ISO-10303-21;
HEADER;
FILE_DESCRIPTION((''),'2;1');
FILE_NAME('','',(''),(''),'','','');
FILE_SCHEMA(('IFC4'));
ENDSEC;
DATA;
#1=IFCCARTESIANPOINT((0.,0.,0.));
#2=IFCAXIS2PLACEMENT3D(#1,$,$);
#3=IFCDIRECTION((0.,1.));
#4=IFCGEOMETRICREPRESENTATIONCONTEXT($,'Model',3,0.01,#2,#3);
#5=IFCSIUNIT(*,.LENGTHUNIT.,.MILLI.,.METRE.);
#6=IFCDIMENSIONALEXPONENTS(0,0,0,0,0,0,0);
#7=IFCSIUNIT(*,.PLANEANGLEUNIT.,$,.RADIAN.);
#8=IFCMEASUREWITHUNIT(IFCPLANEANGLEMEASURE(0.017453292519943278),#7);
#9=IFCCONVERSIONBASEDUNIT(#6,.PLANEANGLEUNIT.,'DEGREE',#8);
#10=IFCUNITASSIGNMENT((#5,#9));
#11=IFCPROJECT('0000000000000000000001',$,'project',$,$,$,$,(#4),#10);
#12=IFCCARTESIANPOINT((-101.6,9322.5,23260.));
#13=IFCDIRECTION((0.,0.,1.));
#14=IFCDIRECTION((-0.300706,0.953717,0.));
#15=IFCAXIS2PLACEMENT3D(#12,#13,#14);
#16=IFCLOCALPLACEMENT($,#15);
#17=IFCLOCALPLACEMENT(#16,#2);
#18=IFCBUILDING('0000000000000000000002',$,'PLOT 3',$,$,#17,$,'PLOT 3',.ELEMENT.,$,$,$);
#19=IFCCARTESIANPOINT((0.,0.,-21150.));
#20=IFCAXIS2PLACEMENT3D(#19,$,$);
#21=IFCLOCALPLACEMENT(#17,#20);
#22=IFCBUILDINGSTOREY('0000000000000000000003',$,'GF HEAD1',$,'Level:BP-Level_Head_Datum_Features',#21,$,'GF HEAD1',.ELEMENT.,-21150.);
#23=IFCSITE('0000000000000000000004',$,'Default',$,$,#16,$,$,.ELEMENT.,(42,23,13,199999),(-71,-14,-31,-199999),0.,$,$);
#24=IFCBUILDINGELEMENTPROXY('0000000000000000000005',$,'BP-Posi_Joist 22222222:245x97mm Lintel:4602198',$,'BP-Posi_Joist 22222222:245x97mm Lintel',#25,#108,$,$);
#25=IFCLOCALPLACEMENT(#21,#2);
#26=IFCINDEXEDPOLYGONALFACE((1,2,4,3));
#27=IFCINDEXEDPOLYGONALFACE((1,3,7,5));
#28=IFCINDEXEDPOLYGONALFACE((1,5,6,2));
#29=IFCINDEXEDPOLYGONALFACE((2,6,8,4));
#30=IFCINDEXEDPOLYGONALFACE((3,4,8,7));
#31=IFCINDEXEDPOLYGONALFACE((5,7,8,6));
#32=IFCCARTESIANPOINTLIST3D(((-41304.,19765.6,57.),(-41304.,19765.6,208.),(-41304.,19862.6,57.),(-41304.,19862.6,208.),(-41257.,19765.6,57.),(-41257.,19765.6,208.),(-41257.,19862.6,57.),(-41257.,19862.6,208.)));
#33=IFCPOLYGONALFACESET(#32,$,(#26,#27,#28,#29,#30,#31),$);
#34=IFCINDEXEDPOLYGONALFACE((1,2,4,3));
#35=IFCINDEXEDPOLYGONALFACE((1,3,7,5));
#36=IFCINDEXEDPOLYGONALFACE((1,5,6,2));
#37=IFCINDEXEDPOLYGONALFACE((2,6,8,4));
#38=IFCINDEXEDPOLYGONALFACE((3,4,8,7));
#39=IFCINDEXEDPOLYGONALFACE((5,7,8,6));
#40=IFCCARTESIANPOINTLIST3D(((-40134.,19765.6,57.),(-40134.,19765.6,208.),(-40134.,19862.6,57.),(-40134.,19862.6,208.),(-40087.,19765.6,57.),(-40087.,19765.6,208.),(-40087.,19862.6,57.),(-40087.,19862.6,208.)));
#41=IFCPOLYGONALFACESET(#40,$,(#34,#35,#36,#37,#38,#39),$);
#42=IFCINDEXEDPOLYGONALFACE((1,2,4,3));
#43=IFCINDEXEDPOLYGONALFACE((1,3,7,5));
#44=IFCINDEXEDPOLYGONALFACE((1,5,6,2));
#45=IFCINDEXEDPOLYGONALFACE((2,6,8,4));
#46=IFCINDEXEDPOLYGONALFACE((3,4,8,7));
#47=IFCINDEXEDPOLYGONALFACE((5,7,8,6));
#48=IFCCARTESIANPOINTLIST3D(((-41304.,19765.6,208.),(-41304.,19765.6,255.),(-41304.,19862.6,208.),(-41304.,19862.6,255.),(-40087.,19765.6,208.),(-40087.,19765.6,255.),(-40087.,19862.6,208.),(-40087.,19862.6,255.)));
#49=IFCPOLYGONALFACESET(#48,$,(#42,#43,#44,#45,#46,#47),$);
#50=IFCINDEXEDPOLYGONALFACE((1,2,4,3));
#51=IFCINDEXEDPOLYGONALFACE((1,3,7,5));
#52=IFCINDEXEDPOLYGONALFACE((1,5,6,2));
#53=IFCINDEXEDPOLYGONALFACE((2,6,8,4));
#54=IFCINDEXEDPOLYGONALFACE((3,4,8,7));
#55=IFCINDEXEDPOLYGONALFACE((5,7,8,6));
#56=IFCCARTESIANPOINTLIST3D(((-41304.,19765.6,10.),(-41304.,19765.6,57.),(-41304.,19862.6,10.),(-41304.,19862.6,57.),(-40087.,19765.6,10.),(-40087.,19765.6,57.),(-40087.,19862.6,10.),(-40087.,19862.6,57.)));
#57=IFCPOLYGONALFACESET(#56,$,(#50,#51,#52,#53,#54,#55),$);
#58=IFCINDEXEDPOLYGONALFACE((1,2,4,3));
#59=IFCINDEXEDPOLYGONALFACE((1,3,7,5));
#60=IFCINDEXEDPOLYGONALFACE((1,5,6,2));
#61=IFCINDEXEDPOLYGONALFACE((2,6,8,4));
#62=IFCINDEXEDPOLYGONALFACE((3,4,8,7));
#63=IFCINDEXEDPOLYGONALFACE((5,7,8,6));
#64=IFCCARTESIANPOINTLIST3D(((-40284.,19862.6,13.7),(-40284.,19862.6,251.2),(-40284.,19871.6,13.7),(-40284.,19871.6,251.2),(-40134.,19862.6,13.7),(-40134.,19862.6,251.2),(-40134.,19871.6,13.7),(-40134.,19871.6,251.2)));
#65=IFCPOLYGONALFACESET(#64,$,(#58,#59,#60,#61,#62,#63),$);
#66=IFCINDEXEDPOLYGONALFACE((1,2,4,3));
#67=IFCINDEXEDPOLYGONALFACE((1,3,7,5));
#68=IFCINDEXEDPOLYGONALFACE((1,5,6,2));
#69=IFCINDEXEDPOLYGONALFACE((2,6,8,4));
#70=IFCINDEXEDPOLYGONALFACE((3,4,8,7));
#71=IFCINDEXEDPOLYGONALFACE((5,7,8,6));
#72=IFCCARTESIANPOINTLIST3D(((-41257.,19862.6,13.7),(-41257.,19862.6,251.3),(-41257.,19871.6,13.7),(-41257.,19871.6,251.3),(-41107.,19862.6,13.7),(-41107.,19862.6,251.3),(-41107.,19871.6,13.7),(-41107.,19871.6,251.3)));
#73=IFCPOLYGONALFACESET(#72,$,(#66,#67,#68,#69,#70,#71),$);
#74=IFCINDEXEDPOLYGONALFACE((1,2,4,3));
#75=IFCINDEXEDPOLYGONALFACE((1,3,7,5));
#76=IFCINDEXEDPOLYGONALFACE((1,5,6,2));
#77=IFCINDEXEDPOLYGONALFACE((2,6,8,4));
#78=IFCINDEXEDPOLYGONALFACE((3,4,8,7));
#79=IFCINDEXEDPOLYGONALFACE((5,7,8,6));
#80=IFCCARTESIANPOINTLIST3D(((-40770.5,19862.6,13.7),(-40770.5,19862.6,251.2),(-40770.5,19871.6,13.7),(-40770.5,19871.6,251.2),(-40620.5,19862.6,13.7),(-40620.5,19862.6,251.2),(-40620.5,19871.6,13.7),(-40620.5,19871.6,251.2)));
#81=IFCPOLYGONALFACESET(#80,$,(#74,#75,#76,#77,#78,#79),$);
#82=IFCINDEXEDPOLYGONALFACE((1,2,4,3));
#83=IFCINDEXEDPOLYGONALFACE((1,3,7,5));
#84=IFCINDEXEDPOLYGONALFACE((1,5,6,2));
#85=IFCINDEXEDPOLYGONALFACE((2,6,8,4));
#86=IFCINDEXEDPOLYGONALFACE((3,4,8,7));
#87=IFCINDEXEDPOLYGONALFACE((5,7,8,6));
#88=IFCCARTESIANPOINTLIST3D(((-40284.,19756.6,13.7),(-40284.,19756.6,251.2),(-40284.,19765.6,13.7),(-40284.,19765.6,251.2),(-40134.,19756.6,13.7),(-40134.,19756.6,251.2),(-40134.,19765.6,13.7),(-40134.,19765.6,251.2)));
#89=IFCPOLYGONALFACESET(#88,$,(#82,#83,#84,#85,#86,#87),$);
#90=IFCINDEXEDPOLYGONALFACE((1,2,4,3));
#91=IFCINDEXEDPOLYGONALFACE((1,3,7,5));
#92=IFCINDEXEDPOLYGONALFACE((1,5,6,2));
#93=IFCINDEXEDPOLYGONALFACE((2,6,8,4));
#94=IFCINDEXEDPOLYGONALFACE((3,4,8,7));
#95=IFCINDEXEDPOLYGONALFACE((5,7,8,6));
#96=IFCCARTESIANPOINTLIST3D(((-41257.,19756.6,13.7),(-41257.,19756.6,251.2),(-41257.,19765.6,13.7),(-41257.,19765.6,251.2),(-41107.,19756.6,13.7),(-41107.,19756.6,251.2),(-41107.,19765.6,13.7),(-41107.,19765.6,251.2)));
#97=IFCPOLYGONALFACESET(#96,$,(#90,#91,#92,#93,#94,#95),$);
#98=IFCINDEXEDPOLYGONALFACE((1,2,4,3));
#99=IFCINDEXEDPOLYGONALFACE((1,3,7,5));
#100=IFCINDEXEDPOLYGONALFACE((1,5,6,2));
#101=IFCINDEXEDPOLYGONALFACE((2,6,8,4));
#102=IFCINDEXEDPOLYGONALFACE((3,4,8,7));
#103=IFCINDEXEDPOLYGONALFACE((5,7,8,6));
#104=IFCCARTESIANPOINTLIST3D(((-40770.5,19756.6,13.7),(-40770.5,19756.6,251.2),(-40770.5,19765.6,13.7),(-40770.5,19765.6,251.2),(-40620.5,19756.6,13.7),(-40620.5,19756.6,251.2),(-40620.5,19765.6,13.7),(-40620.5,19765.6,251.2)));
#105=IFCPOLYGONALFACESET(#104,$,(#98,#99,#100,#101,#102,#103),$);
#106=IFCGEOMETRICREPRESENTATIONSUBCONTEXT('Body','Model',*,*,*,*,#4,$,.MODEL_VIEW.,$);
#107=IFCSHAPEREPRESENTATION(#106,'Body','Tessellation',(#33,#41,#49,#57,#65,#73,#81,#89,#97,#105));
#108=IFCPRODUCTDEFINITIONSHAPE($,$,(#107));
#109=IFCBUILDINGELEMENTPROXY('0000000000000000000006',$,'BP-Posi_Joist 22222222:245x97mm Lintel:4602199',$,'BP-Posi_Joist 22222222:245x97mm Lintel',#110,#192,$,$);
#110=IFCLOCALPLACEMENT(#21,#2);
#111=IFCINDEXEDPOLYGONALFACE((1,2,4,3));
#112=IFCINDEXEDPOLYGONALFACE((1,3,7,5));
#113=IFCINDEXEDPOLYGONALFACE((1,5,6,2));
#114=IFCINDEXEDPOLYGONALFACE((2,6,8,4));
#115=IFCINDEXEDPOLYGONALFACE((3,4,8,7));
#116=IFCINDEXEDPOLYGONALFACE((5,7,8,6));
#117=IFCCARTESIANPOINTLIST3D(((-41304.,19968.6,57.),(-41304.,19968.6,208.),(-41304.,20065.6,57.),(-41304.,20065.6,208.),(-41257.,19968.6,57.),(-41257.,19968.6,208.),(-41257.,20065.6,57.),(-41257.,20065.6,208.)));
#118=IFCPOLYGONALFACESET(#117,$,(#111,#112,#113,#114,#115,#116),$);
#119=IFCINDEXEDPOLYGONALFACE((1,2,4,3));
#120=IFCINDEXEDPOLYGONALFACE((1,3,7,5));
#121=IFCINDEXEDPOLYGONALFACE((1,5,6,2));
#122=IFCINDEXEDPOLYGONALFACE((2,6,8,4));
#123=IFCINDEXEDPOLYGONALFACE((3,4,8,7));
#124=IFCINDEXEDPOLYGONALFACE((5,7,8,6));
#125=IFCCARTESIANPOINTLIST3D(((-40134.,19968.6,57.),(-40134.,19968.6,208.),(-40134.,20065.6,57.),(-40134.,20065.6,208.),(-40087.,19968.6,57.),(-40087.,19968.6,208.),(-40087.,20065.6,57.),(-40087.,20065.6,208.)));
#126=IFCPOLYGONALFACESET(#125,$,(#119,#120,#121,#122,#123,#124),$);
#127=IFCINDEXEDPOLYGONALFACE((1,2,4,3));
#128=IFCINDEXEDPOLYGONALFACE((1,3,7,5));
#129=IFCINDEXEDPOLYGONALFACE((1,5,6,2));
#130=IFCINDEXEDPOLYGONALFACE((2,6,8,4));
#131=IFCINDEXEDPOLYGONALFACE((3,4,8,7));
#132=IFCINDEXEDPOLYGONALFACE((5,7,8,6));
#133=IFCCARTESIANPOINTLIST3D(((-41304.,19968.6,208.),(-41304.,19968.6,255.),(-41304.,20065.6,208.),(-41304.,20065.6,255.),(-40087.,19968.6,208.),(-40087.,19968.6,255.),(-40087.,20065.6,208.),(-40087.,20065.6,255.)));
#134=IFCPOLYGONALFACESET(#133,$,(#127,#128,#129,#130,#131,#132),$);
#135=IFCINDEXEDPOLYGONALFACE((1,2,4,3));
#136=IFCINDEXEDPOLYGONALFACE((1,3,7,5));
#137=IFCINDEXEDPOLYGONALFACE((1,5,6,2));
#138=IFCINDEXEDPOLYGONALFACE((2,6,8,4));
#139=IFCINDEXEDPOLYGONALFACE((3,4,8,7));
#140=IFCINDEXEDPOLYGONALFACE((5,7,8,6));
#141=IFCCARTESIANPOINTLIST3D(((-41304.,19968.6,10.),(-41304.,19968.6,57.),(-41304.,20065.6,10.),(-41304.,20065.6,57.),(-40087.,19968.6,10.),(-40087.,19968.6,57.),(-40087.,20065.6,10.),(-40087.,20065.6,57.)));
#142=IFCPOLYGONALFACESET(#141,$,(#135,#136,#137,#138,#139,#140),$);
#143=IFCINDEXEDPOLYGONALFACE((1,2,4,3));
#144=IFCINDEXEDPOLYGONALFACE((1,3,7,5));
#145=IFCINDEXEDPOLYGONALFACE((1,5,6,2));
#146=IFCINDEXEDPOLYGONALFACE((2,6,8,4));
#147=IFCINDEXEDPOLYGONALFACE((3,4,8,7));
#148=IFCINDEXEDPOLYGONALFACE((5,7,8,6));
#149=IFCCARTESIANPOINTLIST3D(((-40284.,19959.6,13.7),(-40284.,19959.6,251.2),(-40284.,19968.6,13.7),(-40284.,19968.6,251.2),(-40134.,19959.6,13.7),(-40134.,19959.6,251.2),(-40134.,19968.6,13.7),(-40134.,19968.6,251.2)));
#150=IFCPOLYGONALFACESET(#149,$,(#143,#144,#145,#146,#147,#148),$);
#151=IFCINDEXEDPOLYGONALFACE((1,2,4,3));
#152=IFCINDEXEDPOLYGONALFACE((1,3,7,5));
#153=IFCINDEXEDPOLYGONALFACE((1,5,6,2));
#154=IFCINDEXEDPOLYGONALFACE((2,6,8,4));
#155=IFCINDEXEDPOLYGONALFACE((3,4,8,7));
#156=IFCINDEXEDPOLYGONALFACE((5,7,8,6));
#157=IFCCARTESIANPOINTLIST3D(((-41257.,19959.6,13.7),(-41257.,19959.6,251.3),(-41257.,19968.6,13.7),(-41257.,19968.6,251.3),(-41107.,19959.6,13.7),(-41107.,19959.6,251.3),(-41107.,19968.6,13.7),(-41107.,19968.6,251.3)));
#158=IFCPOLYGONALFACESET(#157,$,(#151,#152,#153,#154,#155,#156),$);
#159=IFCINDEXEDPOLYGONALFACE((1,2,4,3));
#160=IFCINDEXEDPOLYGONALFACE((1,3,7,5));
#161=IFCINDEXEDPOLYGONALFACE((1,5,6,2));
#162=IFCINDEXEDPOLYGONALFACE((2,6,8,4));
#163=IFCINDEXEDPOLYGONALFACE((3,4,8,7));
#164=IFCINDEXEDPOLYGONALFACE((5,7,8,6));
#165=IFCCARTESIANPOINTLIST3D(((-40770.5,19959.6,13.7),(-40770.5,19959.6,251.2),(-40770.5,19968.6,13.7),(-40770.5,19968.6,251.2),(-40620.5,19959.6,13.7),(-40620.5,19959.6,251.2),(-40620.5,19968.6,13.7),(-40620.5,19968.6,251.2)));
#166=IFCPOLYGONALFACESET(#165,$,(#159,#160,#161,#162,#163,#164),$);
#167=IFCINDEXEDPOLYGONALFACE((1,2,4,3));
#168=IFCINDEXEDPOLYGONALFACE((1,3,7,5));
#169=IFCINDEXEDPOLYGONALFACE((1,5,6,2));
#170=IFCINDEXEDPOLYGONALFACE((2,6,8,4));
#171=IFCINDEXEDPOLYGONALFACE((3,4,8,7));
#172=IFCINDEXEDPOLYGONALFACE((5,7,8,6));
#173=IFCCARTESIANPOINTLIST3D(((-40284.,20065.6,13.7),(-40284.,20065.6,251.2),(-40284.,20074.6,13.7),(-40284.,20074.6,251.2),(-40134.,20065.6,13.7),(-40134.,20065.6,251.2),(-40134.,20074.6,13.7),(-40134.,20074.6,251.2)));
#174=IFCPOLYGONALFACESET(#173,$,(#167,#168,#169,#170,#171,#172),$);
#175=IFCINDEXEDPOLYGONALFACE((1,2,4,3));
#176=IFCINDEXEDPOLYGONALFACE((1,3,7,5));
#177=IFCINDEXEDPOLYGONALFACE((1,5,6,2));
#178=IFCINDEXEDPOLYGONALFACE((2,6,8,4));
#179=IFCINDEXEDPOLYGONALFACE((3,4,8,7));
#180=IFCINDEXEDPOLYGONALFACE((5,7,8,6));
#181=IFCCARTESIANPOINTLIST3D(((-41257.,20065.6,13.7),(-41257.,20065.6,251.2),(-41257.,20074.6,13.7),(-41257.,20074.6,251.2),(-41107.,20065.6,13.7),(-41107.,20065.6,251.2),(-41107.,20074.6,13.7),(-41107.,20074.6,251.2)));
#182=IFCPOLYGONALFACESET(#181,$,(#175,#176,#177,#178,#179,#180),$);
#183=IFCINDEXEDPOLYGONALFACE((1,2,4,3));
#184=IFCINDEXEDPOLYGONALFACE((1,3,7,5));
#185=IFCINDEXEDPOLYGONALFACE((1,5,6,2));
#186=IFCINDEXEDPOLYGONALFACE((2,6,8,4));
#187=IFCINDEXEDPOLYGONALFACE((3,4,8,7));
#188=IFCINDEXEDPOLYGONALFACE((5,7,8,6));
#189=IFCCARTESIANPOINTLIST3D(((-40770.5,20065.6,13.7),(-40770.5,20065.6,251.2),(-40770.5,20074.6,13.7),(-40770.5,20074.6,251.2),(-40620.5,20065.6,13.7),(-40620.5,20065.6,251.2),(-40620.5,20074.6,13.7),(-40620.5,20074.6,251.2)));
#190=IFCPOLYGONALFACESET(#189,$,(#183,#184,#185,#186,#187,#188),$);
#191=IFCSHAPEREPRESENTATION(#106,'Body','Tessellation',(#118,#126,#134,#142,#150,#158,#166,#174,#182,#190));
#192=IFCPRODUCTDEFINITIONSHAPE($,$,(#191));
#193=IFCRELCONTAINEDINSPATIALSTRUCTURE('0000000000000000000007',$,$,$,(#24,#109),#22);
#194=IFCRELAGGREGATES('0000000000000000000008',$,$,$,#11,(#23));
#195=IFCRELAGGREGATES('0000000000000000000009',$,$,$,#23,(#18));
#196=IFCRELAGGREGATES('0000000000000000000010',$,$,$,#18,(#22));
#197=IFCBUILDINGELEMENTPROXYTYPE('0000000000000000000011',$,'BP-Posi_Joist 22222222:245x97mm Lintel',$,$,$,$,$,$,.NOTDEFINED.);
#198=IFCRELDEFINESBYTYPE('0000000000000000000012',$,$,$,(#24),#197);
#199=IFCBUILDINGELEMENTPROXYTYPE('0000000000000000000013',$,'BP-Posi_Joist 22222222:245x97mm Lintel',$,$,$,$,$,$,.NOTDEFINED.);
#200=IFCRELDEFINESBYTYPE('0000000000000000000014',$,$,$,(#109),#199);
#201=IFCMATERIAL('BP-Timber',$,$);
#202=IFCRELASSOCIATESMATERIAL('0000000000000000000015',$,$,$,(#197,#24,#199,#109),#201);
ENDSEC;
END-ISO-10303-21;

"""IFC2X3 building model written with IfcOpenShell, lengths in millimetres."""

from ifc_helpers import new_model, entity, si_unit, converted_unit, direction, frame, frame_2d, origin, origin_2d_with_axis, place, context, subcontext, project, spatial, rectangle, extrude, source, transform, mapped, material, type_object, type_shapes, element, save


model = new_model("IFC2X3")

# Units and contexts
model_context = context("Model", 3, precision=0.01, world=origin(), true_north=direction((0.0, 1.0)))
body_context = subcontext(model_context, "Body", "Model", "MODEL_VIEW")
ifc_project = project(units=[si_unit("LENGTHUNIT", "METRE", prefix="MILLI"), converted_unit("PLANEANGLEUNIT", "DEGREE", entity("IfcPlaneAngleMeasure", 0.017453292519943278), si_unit("PLANEANGLEUNIT", "RADIAN"), dimensions=[0, 0, 0, 0, 0, 0, 0])], contexts=[model_context])

# Site, building, storey
site_placement = place(None, frame((-101.6, 9322.5, 23260.0), z_axis=(0.0, 0.0, 1.0), x_axis=(-0.300706, 0.953717, 0.0)))
site = spatial("IfcSite", under=ifc_project, at=site_placement, Name="Default", CompositionType="ELEMENT", RefLatitude=(42, 23, 13, 199999), RefLongitude=(-71, -14, -31, -199999), RefElevation=0.0)
building_placement = place(site_placement, origin())
building = spatial("IfcBuilding", under=site, at=building_placement, Name="PLOT 3", LongName="PLOT 3", CompositionType="ELEMENT")
storey_placement = place(building_placement, frame((0.0, 0.0, -21150.0)))
storey = spatial("IfcBuildingStorey", under=building, at=storey_placement, Name="GF HEAD1", ObjectType="Level:BP-Level_Head_Datum_Features", LongName="GF HEAD1", CompositionType="ELEMENT", Elevation=-21150.0)

# Shared definitions
ifc_material_1 = material(Name="BP-Timber")

# Building element proxies
building_element_proxy_type_1 = type_object("IfcBuildingElementProxyType", Name="BP-Posi_Joist 22222222:245x97mm Lintel", PredefinedType="NOTDEFINED", material=ifc_material_1)
shared_shape_1 = source(origin(), body_context, "Body", "SweptSolid", [
    extrude(rectangle(XDim=47.0, YDim=97.0, at=origin_2d_with_axis()), frame((320.4, 0.0, -198.0), z_axis=(0.0, 0.0, 1.0), x_axis=(-1.0, 0.0, 0.0)), (0.0, 0.0, 1.0), 151.0),
    extrude(rectangle(XDim=47.0, YDim=97.0, at=origin_2d_with_axis()), frame((1490.4, 0.0, -198.0), z_axis=(0.0, 0.0, 1.0), x_axis=(-1.0, 0.0, 0.0)), (0.0, 0.0, 1.0), 151.0),
    extrude(rectangle(XDim=97.0, YDim=1217.0, at=origin_2d_with_axis()), frame((905.4, 0.0, -47.0), z_axis=(0.0, 0.0, 1.0), x_axis=(0.0, -1.0, 0.0)), (0.0, 0.0, 1.0), 47.0),
    extrude(rectangle(XDim=97.0, YDim=1217.0, at=origin_2d_with_axis()), frame((905.4, 0.0, -245.0), z_axis=(0.0, 0.0, 1.0), x_axis=(0.0, -1.0, 0.0)), (0.0, 0.0, 1.0), 47.0),
    extrude(rectangle(XDim=9.0, YDim=150.0, at=frame_2d((0.0, 0.0), x_axis=(1.0, 0.0))), frame((1391.9, 53.0, -241.3), z_axis=(0.0, 0.0, 1.0), x_axis=(0.0, -1.0, 0.0)), (0.0, 0.0, 1.0), 237.5),
    extrude(rectangle(XDim=9.0, YDim=150.0, at=frame_2d((0.0, 0.0), x_axis=(1.0, 0.0))), frame((418.9, 53.0, -241.3), z_axis=(0.0, 0.0, 1.0), x_axis=(0.0, 1.0, 0.0)), (0.0, 0.0, 1.0), 237.5),
    extrude(rectangle(XDim=9.0, YDim=150.0, at=frame_2d((0.0, 0.0), x_axis=(1.0, 0.0))), frame((905.4, 53.0, -241.3), z_axis=(0.0, 0.0, 1.0), x_axis=(0.0, -1.0, 0.0)), (0.0, 0.0, 1.0), 237.5),
    extrude(rectangle(XDim=9.0, YDim=150.0, at=origin_2d_with_axis()), frame((1391.9, -53.0, -241.3), z_axis=(0.0, 0.0, 1.0), x_axis=(0.0, -1.0, 0.0)), (0.0, 0.0, 1.0), 237.5),
    extrude(rectangle(XDim=9.0, YDim=150.0, at=frame_2d((0.0, 0.0), x_axis=(1.0, 0.0))), frame((418.9, -53.0, -241.3), z_axis=(0.0, 0.0, 1.0), x_axis=(0.0, 1.0, 0.0)), (0.0, 0.0, 1.0), 237.5),
    extrude(rectangle(XDim=9.0, YDim=150.0, at=origin_2d_with_axis()), frame((905.4, -53.0, -241.3), z_axis=(0.0, 0.0, 1.0), x_axis=(0.0, -1.0, 0.0)), (0.0, 0.0, 1.0), 237.5),
])
type_shapes(building_element_proxy_type_1, [shared_shape_1])
proxy_1_placement = place(storey_placement, frame((-41600.9, 19814.1, 255.0)))
element("IfcBuildingElementProxy", 1, at=proxy_1_placement, inside=storey, type_object=building_element_proxy_type_1, material=ifc_material_1, Name="BP-Posi_Joist 22222222:245x97mm Lintel:4602198", ObjectType="BP-Posi_Joist 22222222:245x97mm Lintel", context=body_context, shape_type="MappedRepresentation", body=[
    mapped(shared_shape_1, transform((0.0, 0.0, 0.0), scale=1.0)),
])
building_element_proxy_type_2 = type_object("IfcBuildingElementProxyType", Name="BP-Posi_Joist 22222222:245x97mm Lintel", PredefinedType="NOTDEFINED", material=ifc_material_1)
shared_shape_2 = source(origin(), body_context, "Body", "SweptSolid", [
    extrude(rectangle(XDim=97.0, YDim=47.0, at=origin_2d_with_axis()), frame((320.4, 0.0, -198.0), z_axis=(0.0, 0.0, 1.0), x_axis=(0.0, 1.0, 0.0)), (0.0, 0.0, 1.0), 151.0),
    extrude(rectangle(XDim=97.0, YDim=47.0, at=origin_2d_with_axis()), frame((1490.4, 0.0, -198.0), z_axis=(0.0, 0.0, 1.0), x_axis=(0.0, 1.0, 0.0)), (0.0, 0.0, 1.0), 151.0),
    extrude(rectangle(XDim=1217.0, YDim=97.0, at=frame_2d((0.0, 0.0), x_axis=(1.0, 0.0))), frame((905.4, 0.0, -47.0)), (0.0, 0.0, 1.0), 47.0),
    extrude(rectangle(XDim=1217.0, YDim=97.0, at=frame_2d((0.0, 0.0), x_axis=(1.0, 0.0))), frame((905.4, 0.0, -245.0)), (0.0, 0.0, 1.0), 47.0),
    extrude(rectangle(XDim=150.0, YDim=9.0, at=frame_2d((0.0, 0.0), x_axis=(1.0, 0.0))), frame((1391.9, -53.0, -241.3)), (0.0, 0.0, 1.0), 237.5),
    extrude(rectangle(XDim=150.0, YDim=9.0, at=frame_2d((0.0, 0.0), x_axis=(1.0, 0.0))), frame((418.9, -53.0, -241.3), z_axis=(0.0, 0.0, 1.0), x_axis=(-1.0, 0.0, 0.0)), (0.0, 0.0, 1.0), 237.5),
    extrude(rectangle(XDim=150.0, YDim=9.0, at=frame_2d((0.0, 0.0), x_axis=(1.0, 0.0))), frame((905.4, -53.0, -241.3)), (0.0, 0.0, 1.0), 237.5),
    extrude(rectangle(XDim=150.0, YDim=9.0, at=origin_2d_with_axis()), frame((1391.9, 53.0, -241.3)), (0.0, 0.0, 1.0), 237.5),
    extrude(rectangle(XDim=150.0, YDim=9.0, at=frame_2d((0.0, 0.0), x_axis=(1.0, 0.0))), frame((418.9, 53.0, -241.3), z_axis=(0.0, 0.0, 1.0), x_axis=(-1.0, 0.0, 0.0)), (0.0, 0.0, 1.0), 237.5),
    extrude(rectangle(XDim=150.0, YDim=9.0, at=origin_2d_with_axis()), frame((905.4, 53.0, -241.3)), (0.0, 0.0, 1.0), 237.5),
])
type_shapes(building_element_proxy_type_2, [shared_shape_2])
proxy_2_placement = place(storey_placement, frame((-41600.9, 20017.1, 255.0)))
element("IfcBuildingElementProxy", 2, at=proxy_2_placement, inside=storey, type_object=building_element_proxy_type_2, material=ifc_material_1, Name="BP-Posi_Joist 22222222:245x97mm Lintel:4602199", ObjectType="BP-Posi_Joist 22222222:245x97mm Lintel", context=body_context, shape_type="MappedRepresentation", body=[
    mapped(shared_shape_2, transform((0.0, 0.0, 0.0), scale=1.0)),
])

save(model, "model.ifc")
